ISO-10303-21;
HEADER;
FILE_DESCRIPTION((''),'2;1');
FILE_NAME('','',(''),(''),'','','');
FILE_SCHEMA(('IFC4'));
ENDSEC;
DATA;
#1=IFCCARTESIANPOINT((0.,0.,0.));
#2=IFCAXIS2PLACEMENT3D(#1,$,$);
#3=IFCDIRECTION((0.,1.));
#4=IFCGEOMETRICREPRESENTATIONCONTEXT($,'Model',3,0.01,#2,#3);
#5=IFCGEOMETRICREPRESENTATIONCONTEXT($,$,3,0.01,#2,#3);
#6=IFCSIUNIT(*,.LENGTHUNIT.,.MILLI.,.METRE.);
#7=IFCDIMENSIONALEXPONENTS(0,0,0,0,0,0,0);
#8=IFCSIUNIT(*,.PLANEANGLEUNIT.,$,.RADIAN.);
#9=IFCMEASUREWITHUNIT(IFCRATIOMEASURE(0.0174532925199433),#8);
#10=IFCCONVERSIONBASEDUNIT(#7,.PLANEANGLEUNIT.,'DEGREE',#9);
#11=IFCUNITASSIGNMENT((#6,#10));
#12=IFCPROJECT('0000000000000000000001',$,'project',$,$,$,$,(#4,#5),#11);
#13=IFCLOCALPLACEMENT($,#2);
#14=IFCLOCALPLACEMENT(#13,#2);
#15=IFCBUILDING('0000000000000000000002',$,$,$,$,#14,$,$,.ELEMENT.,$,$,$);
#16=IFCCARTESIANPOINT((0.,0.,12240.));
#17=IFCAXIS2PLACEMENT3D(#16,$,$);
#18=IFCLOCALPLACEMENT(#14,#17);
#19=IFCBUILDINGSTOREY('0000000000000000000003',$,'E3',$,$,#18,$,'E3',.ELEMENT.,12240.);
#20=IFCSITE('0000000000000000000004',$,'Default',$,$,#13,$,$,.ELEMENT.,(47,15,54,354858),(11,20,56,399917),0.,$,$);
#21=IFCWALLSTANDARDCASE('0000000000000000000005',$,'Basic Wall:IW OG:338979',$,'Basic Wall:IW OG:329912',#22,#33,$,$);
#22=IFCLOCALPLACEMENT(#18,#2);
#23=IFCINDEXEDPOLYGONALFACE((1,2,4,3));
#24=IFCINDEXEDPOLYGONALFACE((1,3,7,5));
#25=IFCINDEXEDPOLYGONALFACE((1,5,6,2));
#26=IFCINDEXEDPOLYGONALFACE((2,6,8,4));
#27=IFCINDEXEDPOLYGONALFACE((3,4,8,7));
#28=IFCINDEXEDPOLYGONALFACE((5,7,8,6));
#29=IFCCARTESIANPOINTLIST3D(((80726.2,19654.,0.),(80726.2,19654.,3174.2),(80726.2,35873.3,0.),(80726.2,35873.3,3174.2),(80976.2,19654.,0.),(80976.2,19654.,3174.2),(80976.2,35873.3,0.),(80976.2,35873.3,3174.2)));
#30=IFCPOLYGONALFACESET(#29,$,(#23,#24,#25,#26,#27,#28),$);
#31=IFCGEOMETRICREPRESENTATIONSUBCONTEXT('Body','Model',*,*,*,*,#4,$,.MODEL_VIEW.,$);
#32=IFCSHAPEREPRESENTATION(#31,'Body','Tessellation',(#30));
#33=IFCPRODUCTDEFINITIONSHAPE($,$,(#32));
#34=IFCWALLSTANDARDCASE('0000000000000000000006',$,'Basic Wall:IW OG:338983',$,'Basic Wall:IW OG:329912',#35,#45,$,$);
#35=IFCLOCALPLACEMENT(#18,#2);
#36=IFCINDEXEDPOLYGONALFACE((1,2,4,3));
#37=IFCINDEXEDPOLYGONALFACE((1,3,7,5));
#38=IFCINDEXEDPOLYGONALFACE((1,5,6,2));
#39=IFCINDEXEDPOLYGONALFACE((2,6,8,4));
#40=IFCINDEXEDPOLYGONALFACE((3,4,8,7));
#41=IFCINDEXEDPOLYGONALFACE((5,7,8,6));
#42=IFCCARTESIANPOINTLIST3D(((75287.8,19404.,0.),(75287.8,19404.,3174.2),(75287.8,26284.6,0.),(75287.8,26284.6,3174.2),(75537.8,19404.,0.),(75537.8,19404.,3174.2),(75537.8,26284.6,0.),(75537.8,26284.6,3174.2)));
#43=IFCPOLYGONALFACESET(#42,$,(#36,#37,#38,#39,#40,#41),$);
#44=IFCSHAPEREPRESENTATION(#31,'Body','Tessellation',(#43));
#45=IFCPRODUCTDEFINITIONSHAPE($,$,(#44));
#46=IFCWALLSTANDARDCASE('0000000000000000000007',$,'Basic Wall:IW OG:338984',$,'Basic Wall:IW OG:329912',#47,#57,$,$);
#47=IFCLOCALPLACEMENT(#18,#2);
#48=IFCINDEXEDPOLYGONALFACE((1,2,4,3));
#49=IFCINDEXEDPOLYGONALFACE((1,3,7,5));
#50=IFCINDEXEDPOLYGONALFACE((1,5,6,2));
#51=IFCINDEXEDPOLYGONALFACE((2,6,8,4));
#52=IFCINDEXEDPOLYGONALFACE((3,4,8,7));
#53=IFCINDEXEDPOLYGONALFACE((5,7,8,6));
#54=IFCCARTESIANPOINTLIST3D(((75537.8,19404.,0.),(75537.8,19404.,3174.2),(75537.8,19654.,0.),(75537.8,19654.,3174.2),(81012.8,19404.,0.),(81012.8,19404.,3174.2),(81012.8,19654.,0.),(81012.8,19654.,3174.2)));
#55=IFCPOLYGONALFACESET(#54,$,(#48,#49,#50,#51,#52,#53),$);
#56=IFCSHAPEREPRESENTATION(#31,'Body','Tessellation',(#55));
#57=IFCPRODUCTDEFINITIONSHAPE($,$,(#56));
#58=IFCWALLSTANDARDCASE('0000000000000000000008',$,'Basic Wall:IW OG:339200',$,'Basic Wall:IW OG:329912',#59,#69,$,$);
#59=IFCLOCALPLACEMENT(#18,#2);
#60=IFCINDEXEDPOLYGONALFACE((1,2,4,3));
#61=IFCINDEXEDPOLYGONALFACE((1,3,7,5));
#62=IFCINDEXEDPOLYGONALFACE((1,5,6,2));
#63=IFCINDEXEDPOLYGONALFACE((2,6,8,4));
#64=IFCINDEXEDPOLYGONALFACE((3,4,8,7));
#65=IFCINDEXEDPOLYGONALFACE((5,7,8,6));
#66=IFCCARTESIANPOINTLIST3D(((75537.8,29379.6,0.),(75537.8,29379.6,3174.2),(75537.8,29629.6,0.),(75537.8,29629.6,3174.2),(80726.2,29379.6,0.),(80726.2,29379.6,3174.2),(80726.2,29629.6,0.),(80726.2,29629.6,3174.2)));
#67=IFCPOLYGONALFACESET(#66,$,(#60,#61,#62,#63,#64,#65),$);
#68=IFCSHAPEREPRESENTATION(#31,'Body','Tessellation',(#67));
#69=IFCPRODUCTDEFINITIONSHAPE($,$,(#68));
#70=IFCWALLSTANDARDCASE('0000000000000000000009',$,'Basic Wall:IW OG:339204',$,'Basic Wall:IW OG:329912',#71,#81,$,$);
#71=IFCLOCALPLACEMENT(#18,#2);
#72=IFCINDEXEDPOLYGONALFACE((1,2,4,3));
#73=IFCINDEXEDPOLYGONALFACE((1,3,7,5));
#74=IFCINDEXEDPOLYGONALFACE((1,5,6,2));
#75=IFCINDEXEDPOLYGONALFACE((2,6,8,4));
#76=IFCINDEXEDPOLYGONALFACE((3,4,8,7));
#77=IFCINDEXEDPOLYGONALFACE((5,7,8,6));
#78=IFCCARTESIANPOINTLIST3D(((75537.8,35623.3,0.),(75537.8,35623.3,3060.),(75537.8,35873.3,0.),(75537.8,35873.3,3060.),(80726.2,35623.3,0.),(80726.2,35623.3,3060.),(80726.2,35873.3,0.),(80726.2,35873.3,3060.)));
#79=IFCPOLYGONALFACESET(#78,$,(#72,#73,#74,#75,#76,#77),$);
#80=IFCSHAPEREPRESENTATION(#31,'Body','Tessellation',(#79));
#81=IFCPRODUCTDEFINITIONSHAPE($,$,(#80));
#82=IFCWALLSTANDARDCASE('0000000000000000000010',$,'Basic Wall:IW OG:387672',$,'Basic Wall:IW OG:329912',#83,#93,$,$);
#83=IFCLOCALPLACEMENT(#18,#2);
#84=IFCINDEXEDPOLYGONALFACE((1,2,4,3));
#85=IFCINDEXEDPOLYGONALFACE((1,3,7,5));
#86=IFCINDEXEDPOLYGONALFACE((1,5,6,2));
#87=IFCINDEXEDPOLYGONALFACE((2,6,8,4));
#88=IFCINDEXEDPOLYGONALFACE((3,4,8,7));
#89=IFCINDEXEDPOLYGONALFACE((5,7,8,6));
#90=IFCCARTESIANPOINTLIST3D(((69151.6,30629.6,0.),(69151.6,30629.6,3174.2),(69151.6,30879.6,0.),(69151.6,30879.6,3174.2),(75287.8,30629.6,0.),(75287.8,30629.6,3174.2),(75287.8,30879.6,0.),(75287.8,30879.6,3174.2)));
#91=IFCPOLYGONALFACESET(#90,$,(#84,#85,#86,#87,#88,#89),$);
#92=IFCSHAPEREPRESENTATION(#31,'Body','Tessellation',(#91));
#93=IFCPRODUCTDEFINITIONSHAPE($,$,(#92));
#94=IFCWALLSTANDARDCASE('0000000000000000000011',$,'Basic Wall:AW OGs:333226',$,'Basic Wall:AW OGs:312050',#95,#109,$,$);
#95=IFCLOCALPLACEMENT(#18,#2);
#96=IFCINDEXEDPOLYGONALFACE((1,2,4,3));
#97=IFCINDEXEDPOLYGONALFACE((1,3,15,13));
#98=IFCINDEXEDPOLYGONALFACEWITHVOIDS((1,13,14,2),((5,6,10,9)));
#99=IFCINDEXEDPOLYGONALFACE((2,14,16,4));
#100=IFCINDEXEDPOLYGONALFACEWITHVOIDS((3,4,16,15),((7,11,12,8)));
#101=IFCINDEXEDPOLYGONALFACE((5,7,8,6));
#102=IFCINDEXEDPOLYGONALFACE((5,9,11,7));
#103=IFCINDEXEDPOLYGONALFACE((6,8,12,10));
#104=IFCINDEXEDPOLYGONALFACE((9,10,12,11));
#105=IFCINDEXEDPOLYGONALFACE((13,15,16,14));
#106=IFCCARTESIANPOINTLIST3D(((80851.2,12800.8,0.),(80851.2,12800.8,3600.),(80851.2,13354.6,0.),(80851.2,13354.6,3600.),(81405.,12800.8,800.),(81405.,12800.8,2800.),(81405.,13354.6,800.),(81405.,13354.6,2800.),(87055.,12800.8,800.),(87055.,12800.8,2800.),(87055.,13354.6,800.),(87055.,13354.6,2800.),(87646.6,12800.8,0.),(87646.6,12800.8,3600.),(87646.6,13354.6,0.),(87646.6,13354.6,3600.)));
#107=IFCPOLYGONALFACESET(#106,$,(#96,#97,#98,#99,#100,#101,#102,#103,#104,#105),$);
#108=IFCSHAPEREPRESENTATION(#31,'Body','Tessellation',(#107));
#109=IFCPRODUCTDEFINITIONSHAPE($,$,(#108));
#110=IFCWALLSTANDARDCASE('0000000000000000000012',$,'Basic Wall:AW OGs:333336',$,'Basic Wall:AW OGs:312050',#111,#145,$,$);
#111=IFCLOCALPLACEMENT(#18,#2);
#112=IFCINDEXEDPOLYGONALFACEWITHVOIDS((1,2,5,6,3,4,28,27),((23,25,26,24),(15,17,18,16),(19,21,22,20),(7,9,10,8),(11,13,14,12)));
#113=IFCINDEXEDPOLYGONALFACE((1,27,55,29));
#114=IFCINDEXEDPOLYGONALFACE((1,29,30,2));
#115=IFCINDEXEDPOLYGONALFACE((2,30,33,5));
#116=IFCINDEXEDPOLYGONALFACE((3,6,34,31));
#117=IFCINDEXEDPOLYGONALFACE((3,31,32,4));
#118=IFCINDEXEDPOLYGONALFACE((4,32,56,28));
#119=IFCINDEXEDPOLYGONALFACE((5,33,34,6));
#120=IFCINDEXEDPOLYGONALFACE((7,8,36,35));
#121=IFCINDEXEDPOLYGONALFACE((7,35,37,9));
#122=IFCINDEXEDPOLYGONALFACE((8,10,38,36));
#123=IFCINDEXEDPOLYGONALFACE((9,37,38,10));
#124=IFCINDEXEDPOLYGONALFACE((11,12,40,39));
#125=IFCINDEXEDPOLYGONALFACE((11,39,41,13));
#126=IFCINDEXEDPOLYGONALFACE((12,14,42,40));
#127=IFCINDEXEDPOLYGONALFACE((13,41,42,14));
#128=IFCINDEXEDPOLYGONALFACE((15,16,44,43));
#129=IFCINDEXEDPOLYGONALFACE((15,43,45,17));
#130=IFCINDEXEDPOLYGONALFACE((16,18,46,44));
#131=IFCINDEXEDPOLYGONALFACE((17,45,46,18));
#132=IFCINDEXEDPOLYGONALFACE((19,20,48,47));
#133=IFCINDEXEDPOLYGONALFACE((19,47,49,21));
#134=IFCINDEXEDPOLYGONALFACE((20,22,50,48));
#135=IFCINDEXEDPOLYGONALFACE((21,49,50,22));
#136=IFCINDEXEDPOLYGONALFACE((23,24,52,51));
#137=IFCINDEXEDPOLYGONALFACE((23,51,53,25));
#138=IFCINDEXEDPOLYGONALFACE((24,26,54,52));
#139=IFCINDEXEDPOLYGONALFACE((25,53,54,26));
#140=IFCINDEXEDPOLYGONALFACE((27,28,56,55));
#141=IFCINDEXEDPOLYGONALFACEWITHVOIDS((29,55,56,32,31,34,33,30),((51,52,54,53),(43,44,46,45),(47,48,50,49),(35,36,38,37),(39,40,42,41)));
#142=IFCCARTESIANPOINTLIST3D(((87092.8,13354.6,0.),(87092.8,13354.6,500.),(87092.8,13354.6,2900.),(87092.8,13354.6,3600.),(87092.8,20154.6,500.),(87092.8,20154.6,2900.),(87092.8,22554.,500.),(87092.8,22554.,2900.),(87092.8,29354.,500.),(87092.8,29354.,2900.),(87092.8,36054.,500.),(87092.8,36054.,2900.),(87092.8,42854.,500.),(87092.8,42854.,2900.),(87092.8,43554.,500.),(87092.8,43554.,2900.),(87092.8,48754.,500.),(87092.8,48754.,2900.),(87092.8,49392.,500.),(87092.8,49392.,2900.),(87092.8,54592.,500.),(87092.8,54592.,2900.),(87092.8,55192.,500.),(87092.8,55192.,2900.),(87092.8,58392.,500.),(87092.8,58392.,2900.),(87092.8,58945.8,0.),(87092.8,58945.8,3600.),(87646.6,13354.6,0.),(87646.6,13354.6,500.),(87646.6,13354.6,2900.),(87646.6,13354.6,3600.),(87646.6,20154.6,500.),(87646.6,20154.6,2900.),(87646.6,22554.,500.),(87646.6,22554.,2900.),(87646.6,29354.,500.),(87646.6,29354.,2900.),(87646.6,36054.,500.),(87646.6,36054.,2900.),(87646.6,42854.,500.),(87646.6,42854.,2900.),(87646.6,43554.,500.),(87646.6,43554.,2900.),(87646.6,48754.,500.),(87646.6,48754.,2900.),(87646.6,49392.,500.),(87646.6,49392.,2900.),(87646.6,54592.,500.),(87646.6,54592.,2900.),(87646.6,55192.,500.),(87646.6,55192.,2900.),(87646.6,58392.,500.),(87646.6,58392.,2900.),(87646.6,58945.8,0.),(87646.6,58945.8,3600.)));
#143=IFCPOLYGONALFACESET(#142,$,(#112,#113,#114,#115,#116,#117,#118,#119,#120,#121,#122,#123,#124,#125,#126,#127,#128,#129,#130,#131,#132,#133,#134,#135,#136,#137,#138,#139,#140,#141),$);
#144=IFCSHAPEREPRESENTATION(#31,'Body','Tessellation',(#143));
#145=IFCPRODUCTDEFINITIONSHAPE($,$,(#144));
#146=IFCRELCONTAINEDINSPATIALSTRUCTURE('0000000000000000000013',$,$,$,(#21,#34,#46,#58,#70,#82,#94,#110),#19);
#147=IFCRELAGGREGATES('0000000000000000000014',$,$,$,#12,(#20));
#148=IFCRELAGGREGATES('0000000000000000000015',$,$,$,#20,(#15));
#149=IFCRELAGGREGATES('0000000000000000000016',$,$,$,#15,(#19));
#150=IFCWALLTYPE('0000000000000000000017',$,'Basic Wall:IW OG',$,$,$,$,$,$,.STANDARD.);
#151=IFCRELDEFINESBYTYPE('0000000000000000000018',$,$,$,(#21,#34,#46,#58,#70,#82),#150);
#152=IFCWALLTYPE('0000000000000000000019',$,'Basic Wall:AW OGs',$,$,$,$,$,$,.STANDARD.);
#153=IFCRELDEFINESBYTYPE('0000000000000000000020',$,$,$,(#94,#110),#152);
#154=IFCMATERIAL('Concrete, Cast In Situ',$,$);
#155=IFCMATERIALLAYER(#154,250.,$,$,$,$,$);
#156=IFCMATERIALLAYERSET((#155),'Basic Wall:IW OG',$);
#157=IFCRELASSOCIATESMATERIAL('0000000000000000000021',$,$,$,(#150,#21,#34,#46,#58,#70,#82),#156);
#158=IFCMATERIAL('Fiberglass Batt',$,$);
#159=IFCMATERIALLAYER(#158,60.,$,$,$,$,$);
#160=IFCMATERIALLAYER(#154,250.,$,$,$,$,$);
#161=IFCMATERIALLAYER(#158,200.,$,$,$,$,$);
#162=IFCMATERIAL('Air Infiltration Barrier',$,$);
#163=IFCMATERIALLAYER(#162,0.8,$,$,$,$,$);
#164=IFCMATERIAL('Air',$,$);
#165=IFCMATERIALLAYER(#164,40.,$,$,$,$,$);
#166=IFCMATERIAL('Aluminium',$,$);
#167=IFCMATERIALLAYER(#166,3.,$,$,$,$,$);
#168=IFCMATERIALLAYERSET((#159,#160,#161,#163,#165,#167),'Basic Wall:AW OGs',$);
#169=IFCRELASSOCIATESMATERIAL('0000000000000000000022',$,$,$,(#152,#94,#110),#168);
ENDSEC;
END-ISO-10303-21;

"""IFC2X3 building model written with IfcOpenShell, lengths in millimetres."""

from ifc_helpers import new_model, entity, si_unit, converted_unit, direction, frame, frame_2d, origin, place, context, subcontext, project, spatial, polyline, rectangle, extrude, clip, bounded_halfspace, material, layer, layer_set, layer_usage, type_object, element, save


model = new_model("IFC2X3")

# Units and contexts
model_context = context("Model", 3, precision=0.01, world=origin(), true_north=direction((0.0, 1.0)))
context_of_model = context(None, 3, precision=0.01, world=origin(), true_north=direction((0.0, 1.0)))
body_context = subcontext(model_context, "Body", "Model", "MODEL_VIEW")
ifc_project = project(units=[si_unit("LENGTHUNIT", "METRE", prefix="MILLI"), converted_unit("PLANEANGLEUNIT", "DEGREE", entity("IfcRatioMeasure", 0.0174532925199433), si_unit("PLANEANGLEUNIT", "RADIAN"), dimensions=[0, 0, 0, 0, 0, 0, 0])], contexts=[model_context, context_of_model])

# Site, building, storey
site_placement = place(None, origin())
site = spatial("IfcSite", under=ifc_project, at=site_placement, Name="Default", CompositionType="ELEMENT", RefLatitude=(47, 15, 54, 354858), RefLongitude=(11, 20, 56, 399917), RefElevation=0.0)
building_placement = place(site_placement, origin())
building = spatial("IfcBuilding", under=site, at=building_placement, CompositionType="ELEMENT")
storey_placement = place(building_placement, frame((0.0, 0.0, 12240.0)))
storey = spatial("IfcBuildingStorey", under=building, at=storey_placement, Name="E3", LongName="E3", CompositionType="ELEMENT", Elevation=12240.0)

# Walls
ifc_material_1 = material(Name="Concrete, Cast In Situ")
ifc_layer_1 = layer(ifc_material_1, 250.0)
ifc_layer_set_1 = layer_set([ifc_layer_1], Name="Basic Wall:IW OG")
wall_type_1 = type_object("IfcWallType", Name="Basic Wall:IW OG", PredefinedType="STANDARD", material=ifc_layer_set_1)
ifc_layer_usage_1 = layer_usage(ifc_layer_set_1, "AXIS2", "NEGATIVE", 125.0)
wall_1_placement = place(storey_placement, frame((80851.2, 35873.3, 0.0), z_axis=(0.0, 0.0, 1.0), x_axis=(0.0, -1.0, 0.0)))
element("IfcWallStandardCase", 1, at=wall_1_placement, inside=storey, type_object=wall_type_1, material=ifc_layer_usage_1, Name="Basic Wall:IW OG:338979", ObjectType="Basic Wall:IW OG:329912", context=body_context, shape_type="Clipping", body=[
    clip(extrude(rectangle(XDim=16219.3, YDim=250.0, at=frame_2d((8109.7, 0.0), x_axis=(-1.0, 0.0))), origin(), (0.0, 0.0, 1.0), 3174.2), bounded_halfspace(frame((0.0, -125.0, 3174.2), z_axis=(0.0, 0.0, -1.0), x_axis=(1.0, 0.0, 0.0)), True, frame((0.0, -125.0, 3174.2)), polyline([(0.0, 0.0), (16219.3, 0.0), (16219.3, 250.0), (0.0, 250.0), (0.0, 0.0)]))),
])
ifc_layer_usage_2 = layer_usage(ifc_layer_set_1, "AXIS2", "NEGATIVE", 125.0)
wall_2_placement = place(storey_placement, frame((75412.8, 26284.6, 0.0), z_axis=(0.0, 0.0, 1.0), x_axis=(0.0, -1.0, 0.0)))
element("IfcWallStandardCase", 2, at=wall_2_placement, inside=storey, type_object=wall_type_1, material=ifc_layer_usage_2, Name="Basic Wall:IW OG:338983", ObjectType="Basic Wall:IW OG:329912", context=body_context, shape_type="Clipping", body=[
    clip(extrude(rectangle(XDim=6880.6, YDim=250.0, at=frame_2d((3440.3, 0.0), x_axis=(-1.0, 0.0))), origin(), (0.0, 0.0, 1.0), 3174.2), bounded_halfspace(frame((0.0, -125.0, 3174.2), z_axis=(0.0, 0.0, -1.0), x_axis=(1.0, 0.0, 0.0)), True, frame((0.0, -125.0, 3174.2)), polyline([(0.0, 0.0), (6880.6, 0.0), (6880.6, 250.0), (6630.6, 250.0), (0.0, 250.0), (0.0, 0.0)]))),
])
ifc_layer_usage_3 = layer_usage(ifc_layer_set_1, "AXIS2", "NEGATIVE", 125.0)
wall_3_placement = place(storey_placement, frame((75537.8, 19529.0, 0.0)))
element("IfcWallStandardCase", 3, at=wall_3_placement, inside=storey, type_object=wall_type_1, material=ifc_layer_usage_3, Name="Basic Wall:IW OG:338984", ObjectType="Basic Wall:IW OG:329912", context=body_context, shape_type="Clipping", body=[
    clip(extrude(rectangle(XDim=5475.0, YDim=250.0, at=frame_2d((2737.5, 0.0), x_axis=(-1.0, 0.0))), origin(), (0.0, 0.0, 1.0), 3174.2), bounded_halfspace(frame((0.0, -125.0, 3174.2), z_axis=(0.0, 0.0, -1.0), x_axis=(0.0, -1.0, 0.0)), True, frame((0.0, -125.0, 3174.2)), polyline([(0.0, 0.0), (5475.0, 0.0), (5475.0, 250.0), (5438.4, 250.0), (5188.4, 250.0), (0.0, 250.0), (0.0, 0.0)]))),
])
ifc_layer_usage_4 = layer_usage(ifc_layer_set_1, "AXIS2", "NEGATIVE", 125.0)
wall_4_placement = place(storey_placement, frame((75537.8, 29504.6, 0.0)))
element("IfcWallStandardCase", 4, at=wall_4_placement, inside=storey, type_object=wall_type_1, material=ifc_layer_usage_4, Name="Basic Wall:IW OG:339200", ObjectType="Basic Wall:IW OG:329912", context=body_context, shape_type="Clipping", body=[
    clip(extrude(rectangle(XDim=5188.4, YDim=250.0, at=frame_2d((2594.2, 0.0), x_axis=(-1.0, 0.0))), origin(), (0.0, 0.0, 1.0), 3174.2), bounded_halfspace(frame((0.0, -125.0, 3174.2), z_axis=(0.0, 0.0, -1.0), x_axis=(0.0, -1.0, 0.0)), True, frame((0.0, -125.0, 3174.2)), polyline([(0.0, 0.0), (5188.4, 0.0), (5188.4, 250.0), (0.0, 250.0), (0.0, 0.0)]))),
])
ifc_layer_usage_5 = layer_usage(ifc_layer_set_1, "AXIS2", "NEGATIVE", 125.0)
wall_5_placement = place(storey_placement, frame((80726.2, 35748.3, 0.0), z_axis=(0.0, 0.0, 1.0), x_axis=(-1.0, 0.0, 0.0)))
element("IfcWallStandardCase", 5, at=wall_5_placement, inside=storey, type_object=wall_type_1, material=ifc_layer_usage_5, Name="Basic Wall:IW OG:339204", ObjectType="Basic Wall:IW OG:329912", context=body_context, shape_type="SweptSolid", body=[
    extrude(rectangle(XDim=5188.4, YDim=250.0, at=frame_2d((2594.2, 0.0), x_axis=(-1.0, 0.0))), origin(), (0.0, 0.0, 1.0), 3060.0),
])
ifc_layer_usage_6 = layer_usage(ifc_layer_set_1, "AXIS2", "NEGATIVE", 125.0)
wall_6_placement = place(storey_placement, frame((75287.8, 30754.6, 0.0), z_axis=(0.0, 0.0, 1.0), x_axis=(-1.0, 0.0, 0.0)))
element("IfcWallStandardCase", 6, at=wall_6_placement, inside=storey, type_object=wall_type_1, material=ifc_layer_usage_6, Name="Basic Wall:IW OG:387672", ObjectType="Basic Wall:IW OG:329912", context=body_context, shape_type="Clipping", body=[
    clip(extrude(rectangle(XDim=6136.2, YDim=250.0, at=frame_2d((3068.1, 0.0), x_axis=(-1.0, 0.0))), origin(), (0.0, 0.0, 1.0), 3174.2), bounded_halfspace(frame((0.0, -125.0, 3174.2), z_axis=(0.0, 0.0, -1.0), x_axis=(0.0, 1.0, 0.0)), True, frame((0.0, -125.0, 3174.2)), polyline([(0.0, 0.0), (6136.2, 0.0), (6136.2, 250.0), (0.0, 250.0), (0.0, 0.0)]))),
])

# Wall, opening
ifc_material_2 = material(Name="Fiberglass Batt")
ifc_layer_2 = layer(ifc_material_2, 60.0)
ifc_layer_3 = layer(ifc_material_1, 250.0)
ifc_layer_4 = layer(ifc_material_2, 200.0)
ifc_material_3 = material(Name="Air Infiltration Barrier")
ifc_layer_5 = layer(ifc_material_3, 0.8)
ifc_material_4 = material(Name="Air")
ifc_layer_6 = layer(ifc_material_4, 40.0)
ifc_material_5 = material(Name="Aluminium")
ifc_layer_7 = layer(ifc_material_5, 3.0)
ifc_layer_set_2 = layer_set([ifc_layer_2, ifc_layer_3, ifc_layer_4, ifc_layer_5, ifc_layer_6, ifc_layer_7], Name="Basic Wall:AW OGs")
ifc_layer_usage_7 = layer_usage(ifc_layer_set_2, "AXIS2", "NEGATIVE", 276.9)
wall_type_2 = type_object("IfcWallType", Name="Basic Wall:AW OGs", PredefinedType="STANDARD", material=ifc_layer_set_2)
wall_7_placement = place(storey_placement, frame((80851.2, 13077.7, 0.0)))
wall_7 = element("IfcWallStandardCase", 7, at=wall_7_placement, inside=storey, type_object=wall_type_2, material=ifc_layer_usage_7, Name="Basic Wall:AW OGs:333226", ObjectType="Basic Wall:AW OGs:312050", context=body_context, shape_type="SweptSolid", body=[
    extrude(rectangle(XDim=6795.4, YDim=553.8, at=frame_2d((3397.7, 0.0), x_axis=(-1.0, 0.0))), origin(), (0.0, 0.0, 1.0), 3600.0),
])
opening_1_placement = place(wall_7_placement, frame((6203.8, 276.9, 800.0)))
element("IfcOpeningElement", 8, at=opening_1_placement, cuts=wall_7, ObjectType="Opening", context=body_context, shape_type="SweptSolid", body=[
    extrude(rectangle(XDim=2000.0, YDim=5650.0, at=frame_2d((1000.0, 2825.0), x_axis=(-1.0, 0.0))), frame((0.0, 0.0, 0.0), z_axis=(0.0, -1.0, 0.0), x_axis=(0.0, 0.0, 1.0)), (0.0, 0.0, 1.0), 553.8),
])

# Wall, openings
ifc_layer_usage_8 = layer_usage(ifc_layer_set_2, "AXIS2", "NEGATIVE", 276.9)
wall_8_placement = place(storey_placement, frame((87369.7, 13354.6, 0.0), z_axis=(0.0, 0.0, 1.0), x_axis=(0.0, 1.0, 0.0)))
wall_8 = element("IfcWallStandardCase", 9, at=wall_8_placement, inside=storey, type_object=wall_type_2, material=ifc_layer_usage_8, Name="Basic Wall:AW OGs:333336", ObjectType="Basic Wall:AW OGs:312050", context=body_context, shape_type="SweptSolid", body=[
    extrude(rectangle(XDim=45591.2, YDim=553.8, at=frame_2d((22795.6, 0.0), x_axis=(-1.0, 0.0))), origin(), (0.0, 0.0, 1.0), 3600.0),
])
opening_2_placement = place(wall_8_placement, frame((6800.0, 276.9, 500.0)))
element("IfcOpeningElement", 10, at=opening_2_placement, cuts=wall_8, ObjectType="Opening", context=body_context, shape_type="SweptSolid", body=[
    extrude(rectangle(XDim=2400.0, YDim=6800.0, at=frame_2d((1200.0, 3400.0), x_axis=(-1.0, 0.0))), frame((0.0, 0.0, 0.0), z_axis=(0.0, -1.0, 0.0), x_axis=(0.0, 0.0, 1.0)), (0.0, 0.0, 1.0), 553.8),
])
opening_3_placement = place(wall_8_placement, frame((45037.4, 276.9, 500.0)))
element("IfcOpeningElement", 11, at=opening_3_placement, cuts=wall_8, ObjectType="Opening", context=body_context, shape_type="SweptSolid", body=[
    extrude(rectangle(XDim=2400.0, YDim=3200.0, at=frame_2d((1200.0, 1600.0), x_axis=(-1.0, 0.0))), frame((0.0, 0.0, 0.0), z_axis=(0.0, -1.0, 0.0), x_axis=(0.0, 0.0, 1.0)), (0.0, 0.0, 1.0), 553.8),
])
opening_4_placement = place(wall_8_placement, frame((29499.4, 276.9, 500.0)))
element("IfcOpeningElement", 12, at=opening_4_placement, cuts=wall_8, ObjectType="Opening", context=body_context, shape_type="SweptSolid", body=[
    extrude(rectangle(XDim=2400.0, YDim=6800.0, at=frame_2d((1200.0, 3400.0), x_axis=(-1.0, 0.0))), frame((0.0, 0.0, 0.0), z_axis=(0.0, -1.0, 0.0), x_axis=(0.0, 0.0, 1.0)), (0.0, 0.0, 1.0), 553.8),
])
opening_5_placement = place(wall_8_placement, frame((15999.4, 276.9, 500.0)))
element("IfcOpeningElement", 13, at=opening_5_placement, cuts=wall_8, ObjectType="Opening", context=body_context, shape_type="SweptSolid", body=[
    extrude(rectangle(XDim=2400.0, YDim=6800.0, at=frame_2d((1200.0, 3400.0), x_axis=(-1.0, 0.0))), frame((0.0, 0.0, 0.0), z_axis=(0.0, -1.0, 0.0), x_axis=(0.0, 0.0, 1.0)), (0.0, 0.0, 1.0), 553.8),
])
opening_6_placement = place(wall_8_placement, frame((35399.4, 276.9, 500.0)))
element("IfcOpeningElement", 14, at=opening_6_placement, cuts=wall_8, ObjectType="Opening", context=body_context, shape_type="SweptSolid", body=[
    extrude(rectangle(XDim=2400.0, YDim=5200.0, at=frame_2d((1200.0, 2600.0), x_axis=(-1.0, 0.0))), frame((0.0, 0.0, 0.0), z_axis=(0.0, -1.0, 0.0), x_axis=(0.0, 0.0, 1.0)), (0.0, 0.0, 1.0), 553.8),
])
opening_7_placement = place(wall_8_placement, frame((41237.4, 276.9, 500.0)))
element("IfcOpeningElement", 15, at=opening_7_placement, cuts=wall_8, ObjectType="Opening", context=body_context, shape_type="SweptSolid", body=[
    extrude(rectangle(XDim=2400.0, YDim=5200.0, at=frame_2d((1200.0, 2600.0), x_axis=(-1.0, 0.0))), frame((0.0, 0.0, 0.0), z_axis=(0.0, -1.0, 0.0), x_axis=(0.0, 0.0, 1.0)), (0.0, 0.0, 1.0), 553.8),
])

save(model, "model.ifc")
